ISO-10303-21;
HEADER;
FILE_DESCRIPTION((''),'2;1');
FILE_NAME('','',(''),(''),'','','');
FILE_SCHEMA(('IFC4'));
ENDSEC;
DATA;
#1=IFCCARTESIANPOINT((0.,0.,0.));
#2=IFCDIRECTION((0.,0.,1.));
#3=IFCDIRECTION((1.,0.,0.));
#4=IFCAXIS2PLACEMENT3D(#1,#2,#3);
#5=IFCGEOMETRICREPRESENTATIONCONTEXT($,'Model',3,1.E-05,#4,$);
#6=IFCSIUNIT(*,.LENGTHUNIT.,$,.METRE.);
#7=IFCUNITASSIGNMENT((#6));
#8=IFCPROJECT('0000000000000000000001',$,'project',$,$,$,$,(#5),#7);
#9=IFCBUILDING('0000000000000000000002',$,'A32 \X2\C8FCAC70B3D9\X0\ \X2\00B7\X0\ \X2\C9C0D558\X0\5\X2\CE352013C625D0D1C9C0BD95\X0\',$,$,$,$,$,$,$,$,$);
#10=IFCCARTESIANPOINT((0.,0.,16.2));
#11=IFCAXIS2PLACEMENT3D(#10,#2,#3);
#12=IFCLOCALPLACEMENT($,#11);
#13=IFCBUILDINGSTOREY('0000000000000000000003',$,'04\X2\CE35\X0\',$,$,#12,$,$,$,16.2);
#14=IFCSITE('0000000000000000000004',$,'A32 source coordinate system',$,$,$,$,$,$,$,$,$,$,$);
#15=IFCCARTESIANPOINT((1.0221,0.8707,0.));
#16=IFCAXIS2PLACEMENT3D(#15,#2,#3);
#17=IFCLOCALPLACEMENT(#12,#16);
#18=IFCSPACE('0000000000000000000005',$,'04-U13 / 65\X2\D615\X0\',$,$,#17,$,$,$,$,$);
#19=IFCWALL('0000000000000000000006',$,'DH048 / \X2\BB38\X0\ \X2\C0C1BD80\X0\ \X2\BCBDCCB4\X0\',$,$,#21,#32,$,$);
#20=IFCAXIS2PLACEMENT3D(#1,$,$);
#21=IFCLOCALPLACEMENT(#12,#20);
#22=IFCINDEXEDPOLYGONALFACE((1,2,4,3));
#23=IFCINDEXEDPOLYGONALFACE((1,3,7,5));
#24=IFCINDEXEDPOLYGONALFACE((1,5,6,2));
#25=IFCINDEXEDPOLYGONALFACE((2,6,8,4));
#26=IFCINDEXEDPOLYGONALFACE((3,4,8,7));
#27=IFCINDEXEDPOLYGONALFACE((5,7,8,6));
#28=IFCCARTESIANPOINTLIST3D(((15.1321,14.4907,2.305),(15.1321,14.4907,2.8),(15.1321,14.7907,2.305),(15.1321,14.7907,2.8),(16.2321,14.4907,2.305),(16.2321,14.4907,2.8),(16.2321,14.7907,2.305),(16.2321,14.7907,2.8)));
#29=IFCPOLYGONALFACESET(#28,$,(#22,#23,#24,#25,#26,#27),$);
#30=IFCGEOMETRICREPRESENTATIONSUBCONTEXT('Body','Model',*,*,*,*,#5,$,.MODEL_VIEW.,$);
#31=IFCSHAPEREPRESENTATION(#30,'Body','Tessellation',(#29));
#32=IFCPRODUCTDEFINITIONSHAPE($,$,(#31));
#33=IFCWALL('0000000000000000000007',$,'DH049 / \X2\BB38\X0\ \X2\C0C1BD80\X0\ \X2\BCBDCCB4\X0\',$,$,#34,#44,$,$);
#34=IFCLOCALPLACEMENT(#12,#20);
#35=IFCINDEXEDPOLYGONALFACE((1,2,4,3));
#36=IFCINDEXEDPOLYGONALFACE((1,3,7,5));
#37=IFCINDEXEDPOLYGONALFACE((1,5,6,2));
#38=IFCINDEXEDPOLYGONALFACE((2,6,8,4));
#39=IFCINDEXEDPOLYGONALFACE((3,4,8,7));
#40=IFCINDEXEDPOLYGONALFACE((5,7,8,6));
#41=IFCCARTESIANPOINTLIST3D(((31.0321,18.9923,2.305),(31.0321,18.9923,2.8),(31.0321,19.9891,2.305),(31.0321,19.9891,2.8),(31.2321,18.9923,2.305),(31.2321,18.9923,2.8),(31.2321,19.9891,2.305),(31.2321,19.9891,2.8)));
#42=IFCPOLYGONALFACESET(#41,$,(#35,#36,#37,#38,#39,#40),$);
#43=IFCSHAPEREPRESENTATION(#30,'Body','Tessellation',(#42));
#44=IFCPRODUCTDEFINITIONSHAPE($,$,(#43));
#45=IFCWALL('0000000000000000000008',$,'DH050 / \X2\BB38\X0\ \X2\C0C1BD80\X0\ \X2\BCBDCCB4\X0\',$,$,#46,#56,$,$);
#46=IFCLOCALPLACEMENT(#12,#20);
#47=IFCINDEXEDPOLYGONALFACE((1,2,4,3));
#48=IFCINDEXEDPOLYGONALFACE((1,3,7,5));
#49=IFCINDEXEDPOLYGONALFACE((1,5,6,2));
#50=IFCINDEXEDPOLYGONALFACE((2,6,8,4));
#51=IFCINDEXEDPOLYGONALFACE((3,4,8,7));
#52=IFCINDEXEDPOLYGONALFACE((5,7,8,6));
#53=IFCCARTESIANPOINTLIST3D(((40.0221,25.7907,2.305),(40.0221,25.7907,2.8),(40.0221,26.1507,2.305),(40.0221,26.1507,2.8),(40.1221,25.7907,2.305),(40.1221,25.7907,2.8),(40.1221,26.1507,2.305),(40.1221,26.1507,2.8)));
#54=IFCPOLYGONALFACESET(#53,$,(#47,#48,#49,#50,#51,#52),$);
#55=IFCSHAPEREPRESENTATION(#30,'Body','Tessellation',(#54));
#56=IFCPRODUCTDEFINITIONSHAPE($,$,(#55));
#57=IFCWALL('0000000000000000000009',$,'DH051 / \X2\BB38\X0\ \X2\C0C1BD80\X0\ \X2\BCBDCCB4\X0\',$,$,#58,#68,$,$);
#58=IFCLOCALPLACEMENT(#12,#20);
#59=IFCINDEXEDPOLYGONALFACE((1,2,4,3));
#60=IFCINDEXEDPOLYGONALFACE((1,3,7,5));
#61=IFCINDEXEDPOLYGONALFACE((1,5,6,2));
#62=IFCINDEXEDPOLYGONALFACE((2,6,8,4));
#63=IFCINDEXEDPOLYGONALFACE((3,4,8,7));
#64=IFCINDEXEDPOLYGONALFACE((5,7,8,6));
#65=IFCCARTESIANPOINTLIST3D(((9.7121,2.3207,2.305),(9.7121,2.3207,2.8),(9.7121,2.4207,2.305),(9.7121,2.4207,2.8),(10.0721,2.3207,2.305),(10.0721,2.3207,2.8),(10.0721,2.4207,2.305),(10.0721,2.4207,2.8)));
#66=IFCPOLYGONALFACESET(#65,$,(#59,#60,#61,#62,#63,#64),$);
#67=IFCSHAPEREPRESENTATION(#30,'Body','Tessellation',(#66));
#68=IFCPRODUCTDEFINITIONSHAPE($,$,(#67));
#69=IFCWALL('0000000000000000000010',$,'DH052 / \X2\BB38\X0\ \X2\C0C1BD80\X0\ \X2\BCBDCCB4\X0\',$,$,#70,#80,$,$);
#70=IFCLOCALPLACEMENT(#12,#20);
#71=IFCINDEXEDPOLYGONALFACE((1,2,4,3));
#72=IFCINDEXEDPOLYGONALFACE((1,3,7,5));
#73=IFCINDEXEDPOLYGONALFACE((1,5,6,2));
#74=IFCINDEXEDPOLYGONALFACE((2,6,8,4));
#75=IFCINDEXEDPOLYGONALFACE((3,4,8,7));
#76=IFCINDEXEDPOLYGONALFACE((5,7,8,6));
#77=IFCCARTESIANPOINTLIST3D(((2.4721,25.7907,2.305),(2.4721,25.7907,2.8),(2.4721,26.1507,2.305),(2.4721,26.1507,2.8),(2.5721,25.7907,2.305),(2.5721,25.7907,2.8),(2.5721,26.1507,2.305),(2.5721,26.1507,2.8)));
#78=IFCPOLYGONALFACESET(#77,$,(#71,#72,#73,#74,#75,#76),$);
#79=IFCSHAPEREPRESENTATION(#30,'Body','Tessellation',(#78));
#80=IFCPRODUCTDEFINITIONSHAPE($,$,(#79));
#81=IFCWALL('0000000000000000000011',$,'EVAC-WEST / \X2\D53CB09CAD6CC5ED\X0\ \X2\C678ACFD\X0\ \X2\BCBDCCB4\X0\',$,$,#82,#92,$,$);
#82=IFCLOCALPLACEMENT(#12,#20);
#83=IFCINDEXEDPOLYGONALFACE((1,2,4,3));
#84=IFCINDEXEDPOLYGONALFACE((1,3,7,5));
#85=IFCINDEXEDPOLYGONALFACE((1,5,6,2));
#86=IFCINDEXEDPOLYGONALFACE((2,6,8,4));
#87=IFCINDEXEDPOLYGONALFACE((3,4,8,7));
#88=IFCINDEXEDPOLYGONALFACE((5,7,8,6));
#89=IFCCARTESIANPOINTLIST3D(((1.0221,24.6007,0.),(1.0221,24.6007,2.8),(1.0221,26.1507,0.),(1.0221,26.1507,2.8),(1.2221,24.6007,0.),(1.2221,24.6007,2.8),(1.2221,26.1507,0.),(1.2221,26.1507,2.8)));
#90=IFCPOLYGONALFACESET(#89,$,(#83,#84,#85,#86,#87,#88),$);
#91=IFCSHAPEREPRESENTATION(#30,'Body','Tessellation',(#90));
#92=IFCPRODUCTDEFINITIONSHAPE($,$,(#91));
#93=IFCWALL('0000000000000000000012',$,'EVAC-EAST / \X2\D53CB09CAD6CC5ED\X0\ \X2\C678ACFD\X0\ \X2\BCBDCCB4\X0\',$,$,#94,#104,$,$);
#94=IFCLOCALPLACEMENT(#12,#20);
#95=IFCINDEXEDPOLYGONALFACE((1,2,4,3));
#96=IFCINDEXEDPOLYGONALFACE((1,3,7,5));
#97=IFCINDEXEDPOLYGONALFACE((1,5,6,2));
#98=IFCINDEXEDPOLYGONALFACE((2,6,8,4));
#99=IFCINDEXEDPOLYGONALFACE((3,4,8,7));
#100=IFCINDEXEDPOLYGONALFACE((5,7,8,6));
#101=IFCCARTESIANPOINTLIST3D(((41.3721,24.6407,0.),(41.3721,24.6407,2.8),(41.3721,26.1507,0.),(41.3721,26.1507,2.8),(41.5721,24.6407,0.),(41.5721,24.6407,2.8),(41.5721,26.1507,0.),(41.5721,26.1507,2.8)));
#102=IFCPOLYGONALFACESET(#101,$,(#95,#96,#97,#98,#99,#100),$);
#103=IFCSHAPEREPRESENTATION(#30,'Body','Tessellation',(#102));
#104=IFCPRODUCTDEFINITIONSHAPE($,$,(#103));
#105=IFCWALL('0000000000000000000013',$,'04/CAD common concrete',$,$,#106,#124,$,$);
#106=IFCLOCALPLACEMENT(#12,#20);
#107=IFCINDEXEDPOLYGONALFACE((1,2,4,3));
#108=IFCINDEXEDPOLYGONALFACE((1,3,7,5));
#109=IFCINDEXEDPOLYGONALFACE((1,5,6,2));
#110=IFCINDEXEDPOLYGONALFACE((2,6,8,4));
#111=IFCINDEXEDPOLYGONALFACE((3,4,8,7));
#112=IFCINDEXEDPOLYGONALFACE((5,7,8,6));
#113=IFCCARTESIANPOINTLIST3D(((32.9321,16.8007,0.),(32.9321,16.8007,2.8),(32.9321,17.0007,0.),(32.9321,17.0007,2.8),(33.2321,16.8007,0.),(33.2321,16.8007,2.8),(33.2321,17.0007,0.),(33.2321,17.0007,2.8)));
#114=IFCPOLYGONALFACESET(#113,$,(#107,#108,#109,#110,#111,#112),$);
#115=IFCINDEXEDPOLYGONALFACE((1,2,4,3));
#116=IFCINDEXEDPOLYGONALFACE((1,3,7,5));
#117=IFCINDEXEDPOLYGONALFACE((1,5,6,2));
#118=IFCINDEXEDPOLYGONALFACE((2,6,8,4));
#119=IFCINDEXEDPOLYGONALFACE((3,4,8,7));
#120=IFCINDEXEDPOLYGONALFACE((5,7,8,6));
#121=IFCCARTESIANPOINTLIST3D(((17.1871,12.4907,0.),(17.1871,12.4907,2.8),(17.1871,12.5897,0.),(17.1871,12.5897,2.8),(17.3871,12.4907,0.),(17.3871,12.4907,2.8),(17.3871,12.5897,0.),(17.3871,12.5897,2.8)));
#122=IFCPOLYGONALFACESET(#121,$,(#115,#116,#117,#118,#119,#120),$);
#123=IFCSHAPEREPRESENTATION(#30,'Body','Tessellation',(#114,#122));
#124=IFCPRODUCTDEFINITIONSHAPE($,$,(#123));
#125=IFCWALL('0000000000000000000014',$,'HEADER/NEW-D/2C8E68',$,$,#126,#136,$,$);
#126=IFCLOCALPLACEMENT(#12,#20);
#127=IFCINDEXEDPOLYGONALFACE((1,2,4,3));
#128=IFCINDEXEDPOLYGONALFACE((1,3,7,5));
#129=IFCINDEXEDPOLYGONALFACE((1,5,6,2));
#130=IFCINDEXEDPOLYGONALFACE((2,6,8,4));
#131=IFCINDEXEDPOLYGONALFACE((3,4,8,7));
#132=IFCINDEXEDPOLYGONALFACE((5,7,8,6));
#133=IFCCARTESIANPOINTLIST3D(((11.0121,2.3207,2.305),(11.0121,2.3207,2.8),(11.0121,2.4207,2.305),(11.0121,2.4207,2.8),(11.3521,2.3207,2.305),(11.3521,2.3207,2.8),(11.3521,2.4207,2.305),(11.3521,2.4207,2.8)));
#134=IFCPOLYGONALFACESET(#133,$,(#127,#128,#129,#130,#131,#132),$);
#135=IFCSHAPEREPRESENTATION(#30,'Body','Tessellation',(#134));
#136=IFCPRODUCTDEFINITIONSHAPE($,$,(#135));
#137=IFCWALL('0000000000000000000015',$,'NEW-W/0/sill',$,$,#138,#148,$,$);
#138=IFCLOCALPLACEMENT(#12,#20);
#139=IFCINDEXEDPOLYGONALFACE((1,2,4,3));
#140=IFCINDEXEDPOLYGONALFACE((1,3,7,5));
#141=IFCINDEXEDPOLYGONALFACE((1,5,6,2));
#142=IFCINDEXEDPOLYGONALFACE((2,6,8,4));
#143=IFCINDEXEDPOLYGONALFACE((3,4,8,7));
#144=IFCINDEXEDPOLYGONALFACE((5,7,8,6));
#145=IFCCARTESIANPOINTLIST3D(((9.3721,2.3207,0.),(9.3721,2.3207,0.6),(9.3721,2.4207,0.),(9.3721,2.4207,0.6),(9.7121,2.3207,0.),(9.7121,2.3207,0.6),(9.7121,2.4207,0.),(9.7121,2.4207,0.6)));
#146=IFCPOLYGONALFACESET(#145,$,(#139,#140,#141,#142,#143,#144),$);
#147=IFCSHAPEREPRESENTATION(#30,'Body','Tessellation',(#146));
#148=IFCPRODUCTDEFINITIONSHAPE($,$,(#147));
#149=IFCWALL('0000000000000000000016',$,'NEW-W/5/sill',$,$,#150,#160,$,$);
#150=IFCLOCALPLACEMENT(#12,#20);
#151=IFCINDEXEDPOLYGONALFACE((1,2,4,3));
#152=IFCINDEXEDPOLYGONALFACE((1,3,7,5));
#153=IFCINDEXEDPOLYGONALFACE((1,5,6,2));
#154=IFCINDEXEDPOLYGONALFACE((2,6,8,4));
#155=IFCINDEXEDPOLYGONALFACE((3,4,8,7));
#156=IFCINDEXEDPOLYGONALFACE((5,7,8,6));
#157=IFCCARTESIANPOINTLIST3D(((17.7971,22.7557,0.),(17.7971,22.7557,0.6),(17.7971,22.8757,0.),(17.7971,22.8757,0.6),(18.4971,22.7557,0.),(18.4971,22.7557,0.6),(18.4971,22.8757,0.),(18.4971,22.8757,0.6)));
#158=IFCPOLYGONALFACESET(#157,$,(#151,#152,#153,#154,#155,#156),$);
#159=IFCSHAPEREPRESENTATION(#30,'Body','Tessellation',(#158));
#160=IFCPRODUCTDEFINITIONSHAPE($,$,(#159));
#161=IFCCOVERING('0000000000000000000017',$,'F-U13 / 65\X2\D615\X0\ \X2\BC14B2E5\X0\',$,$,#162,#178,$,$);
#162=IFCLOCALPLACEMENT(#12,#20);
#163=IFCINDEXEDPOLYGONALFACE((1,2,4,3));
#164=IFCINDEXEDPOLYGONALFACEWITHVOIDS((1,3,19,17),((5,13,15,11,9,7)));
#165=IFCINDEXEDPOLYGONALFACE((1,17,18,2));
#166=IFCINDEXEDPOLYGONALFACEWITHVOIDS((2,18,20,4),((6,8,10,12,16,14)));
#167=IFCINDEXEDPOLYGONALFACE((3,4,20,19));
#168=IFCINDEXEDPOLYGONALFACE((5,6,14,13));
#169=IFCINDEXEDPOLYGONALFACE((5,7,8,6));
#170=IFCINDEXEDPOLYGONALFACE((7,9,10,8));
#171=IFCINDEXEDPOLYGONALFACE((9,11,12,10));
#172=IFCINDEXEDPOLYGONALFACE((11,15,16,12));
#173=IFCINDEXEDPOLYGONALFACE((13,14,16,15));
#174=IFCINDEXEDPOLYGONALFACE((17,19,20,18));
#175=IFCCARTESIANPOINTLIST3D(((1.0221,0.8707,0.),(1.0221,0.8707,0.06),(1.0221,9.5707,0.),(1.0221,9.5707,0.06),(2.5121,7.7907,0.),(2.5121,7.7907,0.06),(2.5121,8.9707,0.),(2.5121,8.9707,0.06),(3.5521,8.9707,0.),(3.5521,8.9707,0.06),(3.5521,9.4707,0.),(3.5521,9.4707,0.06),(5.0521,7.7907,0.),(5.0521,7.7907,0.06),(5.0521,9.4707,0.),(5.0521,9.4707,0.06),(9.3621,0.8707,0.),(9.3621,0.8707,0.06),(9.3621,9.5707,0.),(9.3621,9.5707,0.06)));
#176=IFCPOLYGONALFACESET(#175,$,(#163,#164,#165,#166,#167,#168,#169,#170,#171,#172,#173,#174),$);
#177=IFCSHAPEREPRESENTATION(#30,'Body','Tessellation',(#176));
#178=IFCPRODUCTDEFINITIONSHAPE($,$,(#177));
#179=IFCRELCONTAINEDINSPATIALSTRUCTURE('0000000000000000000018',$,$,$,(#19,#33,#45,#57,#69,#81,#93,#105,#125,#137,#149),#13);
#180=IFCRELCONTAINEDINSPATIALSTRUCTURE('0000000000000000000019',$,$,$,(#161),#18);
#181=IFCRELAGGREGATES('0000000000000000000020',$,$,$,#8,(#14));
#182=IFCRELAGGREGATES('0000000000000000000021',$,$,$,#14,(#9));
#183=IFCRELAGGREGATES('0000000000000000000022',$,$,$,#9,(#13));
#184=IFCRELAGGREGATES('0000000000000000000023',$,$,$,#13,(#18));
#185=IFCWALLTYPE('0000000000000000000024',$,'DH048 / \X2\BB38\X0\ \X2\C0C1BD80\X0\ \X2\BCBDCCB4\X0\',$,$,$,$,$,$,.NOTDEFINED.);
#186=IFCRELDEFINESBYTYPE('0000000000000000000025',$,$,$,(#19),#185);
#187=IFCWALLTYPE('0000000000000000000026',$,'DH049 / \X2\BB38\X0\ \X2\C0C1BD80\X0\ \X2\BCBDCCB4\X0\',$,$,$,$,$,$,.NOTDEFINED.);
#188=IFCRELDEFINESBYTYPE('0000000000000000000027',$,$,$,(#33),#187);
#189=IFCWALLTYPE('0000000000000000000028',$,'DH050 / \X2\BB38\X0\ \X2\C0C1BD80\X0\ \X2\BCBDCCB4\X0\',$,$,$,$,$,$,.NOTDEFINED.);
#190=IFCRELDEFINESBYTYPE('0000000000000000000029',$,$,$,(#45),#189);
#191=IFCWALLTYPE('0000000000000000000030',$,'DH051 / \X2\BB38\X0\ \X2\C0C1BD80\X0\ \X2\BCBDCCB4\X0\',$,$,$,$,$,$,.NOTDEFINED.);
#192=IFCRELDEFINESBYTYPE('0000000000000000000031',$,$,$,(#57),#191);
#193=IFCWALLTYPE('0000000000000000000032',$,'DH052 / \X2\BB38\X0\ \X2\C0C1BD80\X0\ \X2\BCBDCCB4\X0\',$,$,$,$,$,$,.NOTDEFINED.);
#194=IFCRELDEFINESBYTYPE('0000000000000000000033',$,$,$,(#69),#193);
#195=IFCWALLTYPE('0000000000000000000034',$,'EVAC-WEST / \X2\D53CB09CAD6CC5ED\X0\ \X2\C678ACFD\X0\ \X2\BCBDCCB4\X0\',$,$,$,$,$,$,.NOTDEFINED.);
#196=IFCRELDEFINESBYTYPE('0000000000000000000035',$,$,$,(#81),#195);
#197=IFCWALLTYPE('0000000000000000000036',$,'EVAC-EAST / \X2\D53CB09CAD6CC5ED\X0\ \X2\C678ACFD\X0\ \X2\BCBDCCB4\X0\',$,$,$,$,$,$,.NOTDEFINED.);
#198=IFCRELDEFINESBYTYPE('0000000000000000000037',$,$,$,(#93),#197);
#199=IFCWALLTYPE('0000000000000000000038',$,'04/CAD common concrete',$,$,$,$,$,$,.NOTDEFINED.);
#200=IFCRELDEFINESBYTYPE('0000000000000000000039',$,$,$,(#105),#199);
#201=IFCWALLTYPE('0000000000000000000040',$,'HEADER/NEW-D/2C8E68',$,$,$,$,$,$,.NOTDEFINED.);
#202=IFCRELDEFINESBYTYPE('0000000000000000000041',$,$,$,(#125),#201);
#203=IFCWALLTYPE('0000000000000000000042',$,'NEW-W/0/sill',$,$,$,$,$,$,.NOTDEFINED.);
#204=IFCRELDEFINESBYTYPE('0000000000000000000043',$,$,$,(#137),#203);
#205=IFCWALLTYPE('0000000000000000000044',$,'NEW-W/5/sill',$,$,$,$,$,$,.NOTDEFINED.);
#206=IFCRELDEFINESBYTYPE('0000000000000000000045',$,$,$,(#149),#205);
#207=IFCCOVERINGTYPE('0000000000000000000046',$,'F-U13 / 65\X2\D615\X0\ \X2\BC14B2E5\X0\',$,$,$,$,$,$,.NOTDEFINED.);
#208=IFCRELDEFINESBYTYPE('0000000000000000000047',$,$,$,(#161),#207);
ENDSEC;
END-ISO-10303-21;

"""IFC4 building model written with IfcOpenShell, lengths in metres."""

from ifc_helpers import new_model, si_unit, frame, origin, origin_with_axes, place, context, subcontext, project, spatial, polyline, outline, extrude, source, transform, mapped, type_object, type_shapes, element, save


model = new_model("IFC4")

# Units and contexts
model_context = context("Model", 3, precision=1e-05, world=origin_with_axes())
body_context = subcontext(model_context, "Body", "Model", "MODEL_VIEW")
ifc_project = project(units=[si_unit("LENGTHUNIT", "METRE")], contexts=[model_context])

# Site, building, storey
site = spatial("IfcSite", under=ifc_project, Name="A32 source coordinate system")
building = spatial("IfcBuilding", under=site, Name="A32 주거동 · 지하5층–옥탑지붕")
storey_placement = place(None, frame((0.0, 0.0, 16.2), z_axis=(0.0, 0.0, 1.0), x_axis=(1.0, 0.0, 0.0)))
storey = spatial("IfcBuildingStorey", under=building, at=storey_placement, Name="04층", Elevation=16.2)

# Walls
wall_type_1 = type_object("IfcWallType", Name="DH048 / 문 상부 벽체", PredefinedType="NOTDEFINED")
shared_shape_1 = source(origin(), body_context, "Body", "SweptSolid", [
    extrude(outline(polyline([(15.1321, 14.7907), (16.2321, 14.7907), (16.2321, 14.4907), (15.1321, 14.4907), (15.1321, 14.7907)])), frame((0.0, 0.0, 2.305)), (0.0, 0.0, 1.0), 0.495),
])
type_shapes(wall_type_1, [shared_shape_1])
wall_1_placement = place(storey_placement, origin_with_axes())
element("IfcWall", 1, at=wall_1_placement, inside=storey, type_object=wall_type_1, Name="DH048 / 문 상부 벽체", context=body_context, shape_type="MappedRepresentation", body=[
    mapped(shared_shape_1, transform((0.0, 0.0, 0.0), scale=1.0)),
])
wall_type_2 = type_object("IfcWallType", Name="DH049 / 문 상부 벽체", PredefinedType="NOTDEFINED")
shared_shape_2 = source(origin(), body_context, "Body", "SweptSolid", [
    extrude(outline(polyline([(31.2321, 18.9923), (31.0321, 18.9923), (31.0321, 19.9891), (31.2321, 19.9891), (31.2321, 18.9923)])), frame((0.0, 0.0, 2.305)), (0.0, 0.0, 1.0), 0.495),
])
type_shapes(wall_type_2, [shared_shape_2])
wall_2_placement = place(storey_placement, origin_with_axes())
element("IfcWall", 2, at=wall_2_placement, inside=storey, type_object=wall_type_2, Name="DH049 / 문 상부 벽체", context=body_context, shape_type="MappedRepresentation", body=[
    mapped(shared_shape_2, transform((0.0, 0.0, 0.0), scale=1.0)),
])
wall_type_3 = type_object("IfcWallType", Name="DH050 / 문 상부 벽체", PredefinedType="NOTDEFINED")
shared_shape_3 = source(origin(), body_context, "Body", "SweptSolid", [
    extrude(outline(polyline([(40.0221, 25.7907), (40.0221, 26.1507), (40.1221, 26.1507), (40.1221, 25.7907), (40.0221, 25.7907)])), frame((0.0, 0.0, 2.305)), (0.0, 0.0, 1.0), 0.495),
])
type_shapes(wall_type_3, [shared_shape_3])
wall_3_placement = place(storey_placement, origin_with_axes())
element("IfcWall", 3, at=wall_3_placement, inside=storey, type_object=wall_type_3, Name="DH050 / 문 상부 벽체", context=body_context, shape_type="MappedRepresentation", body=[
    mapped(shared_shape_3, transform((0.0, 0.0, 0.0), scale=1.0)),
])
wall_type_4 = type_object("IfcWallType", Name="DH051 / 문 상부 벽체", PredefinedType="NOTDEFINED")
shared_shape_4 = source(origin(), body_context, "Body", "SweptSolid", [
    extrude(outline(polyline([(10.0721, 2.3207), (9.7121, 2.3207), (9.7121, 2.4207), (10.0721, 2.4207), (10.0721, 2.3207)])), frame((0.0, 0.0, 2.305)), (0.0, 0.0, 1.0), 0.495),
])
type_shapes(wall_type_4, [shared_shape_4])
wall_4_placement = place(storey_placement, origin_with_axes())
element("IfcWall", 4, at=wall_4_placement, inside=storey, type_object=wall_type_4, Name="DH051 / 문 상부 벽체", context=body_context, shape_type="MappedRepresentation", body=[
    mapped(shared_shape_4, transform((0.0, 0.0, 0.0), scale=1.0)),
])
wall_type_5 = type_object("IfcWallType", Name="DH052 / 문 상부 벽체", PredefinedType="NOTDEFINED")
shared_shape_5 = source(origin(), body_context, "Body", "SweptSolid", [
    extrude(outline(polyline([(2.5721, 25.7907), (2.4721, 25.7907), (2.4721, 26.1507), (2.5721, 26.1507), (2.5721, 25.7907)])), frame((0.0, 0.0, 2.305)), (0.0, 0.0, 1.0), 0.495),
])
type_shapes(wall_type_5, [shared_shape_5])
wall_5_placement = place(storey_placement, origin_with_axes())
element("IfcWall", 5, at=wall_5_placement, inside=storey, type_object=wall_type_5, Name="DH052 / 문 상부 벽체", context=body_context, shape_type="MappedRepresentation", body=[
    mapped(shared_shape_5, transform((0.0, 0.0, 0.0), scale=1.0)),
])
wall_type_6 = type_object("IfcWallType", Name="EVAC-WEST / 피난구역 외곽 벽체", PredefinedType="NOTDEFINED")
shared_shape_6 = source(origin(), body_context, "Body", "SweptSolid", [
    extrude(outline(polyline([(1.2221, 24.6007), (1.0221, 24.6007), (1.0221, 26.1507), (1.2221, 26.1507), (1.2221, 24.6007)])), origin(), (0.0, 0.0, 1.0), 2.8),
])
type_shapes(wall_type_6, [shared_shape_6])
wall_6_placement = place(storey_placement, origin_with_axes())
element("IfcWall", 6, at=wall_6_placement, inside=storey, type_object=wall_type_6, Name="EVAC-WEST / 피난구역 외곽 벽체", context=body_context, shape_type="MappedRepresentation", body=[
    mapped(shared_shape_6, transform((0.0, 0.0, 0.0), scale=1.0)),
])
wall_type_7 = type_object("IfcWallType", Name="EVAC-EAST / 피난구역 외곽 벽체", PredefinedType="NOTDEFINED")
shared_shape_7 = source(origin(), body_context, "Body", "SweptSolid", [
    extrude(outline(polyline([(41.5721, 26.1507), (41.5721, 24.6407), (41.3721, 24.6407), (41.3721, 26.1507), (41.5721, 26.1507)])), origin(), (0.0, 0.0, 1.0), 2.8),
])
type_shapes(wall_type_7, [shared_shape_7])
wall_7_placement = place(storey_placement, origin_with_axes())
element("IfcWall", 7, at=wall_7_placement, inside=storey, type_object=wall_type_7, Name="EVAC-EAST / 피난구역 외곽 벽체", context=body_context, shape_type="MappedRepresentation", body=[
    mapped(shared_shape_7, transform((0.0, 0.0, 0.0), scale=1.0)),
])
wall_type_8 = type_object("IfcWallType", Name="04/CAD common concrete", PredefinedType="NOTDEFINED")
shared_shape_8 = source(origin(), body_context, "Body", "SweptSolid", [
    extrude(outline(polyline([(32.9321, 17.0007), (33.2321, 17.0007), (33.2321, 16.8007), (32.9321, 16.8007), (32.9321, 17.0007)])), origin(), (0.0, 0.0, 1.0), 2.8),
    extrude(outline(polyline([(17.1871, 12.4907), (17.1871, 12.5897), (17.3871, 12.5897), (17.3871, 12.4907), (17.1871, 12.4907)])), origin(), (0.0, 0.0, 1.0), 2.8),
])
type_shapes(wall_type_8, [shared_shape_8])
wall_8_placement = place(storey_placement, origin_with_axes())
element("IfcWall", 8, at=wall_8_placement, inside=storey, type_object=wall_type_8, Name="04/CAD common concrete", context=body_context, shape_type="MappedRepresentation", body=[
    mapped(shared_shape_8, transform((0.0, 0.0, 0.0), scale=1.0)),
])
wall_type_9 = type_object("IfcWallType", Name="HEADER/NEW-D/2C8E68", PredefinedType="NOTDEFINED")
shared_shape_9 = source(origin(), body_context, "Body", "SweptSolid", [
    extrude(outline(polyline([(10.6521, 2.4207), (11.3521, 2.4207), (11.3521, 2.3207), (11.0121, 2.3207), (11.0121, 2.4207), (10.6521, 2.4207), (10.6521, 2.4207)])), frame((0.0, 0.0, 2.305)), (0.0, 0.0, 1.0), 0.495),
])
type_shapes(wall_type_9, [shared_shape_9])
wall_9_placement = place(storey_placement, origin_with_axes())
element("IfcWall", 9, at=wall_9_placement, inside=storey, type_object=wall_type_9, Name="HEADER/NEW-D/2C8E68", context=body_context, shape_type="MappedRepresentation", body=[
    mapped(shared_shape_9, transform((0.0, 0.0, 0.0), scale=1.0)),
])
wall_type_10 = type_object("IfcWallType", Name="NEW-W/0/sill", PredefinedType="NOTDEFINED")
shared_shape_10 = source(origin(), body_context, "Body", "SweptSolid", [
    extrude(outline(polyline([(9.3721, 2.3207), (9.3721, 2.4207), (10.6521, 2.4207), (10.6521, 2.4207), (10.0721, 2.4207), (9.7121, 2.4207), (9.7121, 2.3207), (9.3721, 2.3207)])), origin(), (0.0, 0.0, 1.0), 0.6),
])
type_shapes(wall_type_10, [shared_shape_10])
wall_10_placement = place(storey_placement, origin_with_axes())
element("IfcWall", 10, at=wall_10_placement, inside=storey, type_object=wall_type_10, Name="NEW-W/0/sill", context=body_context, shape_type="MappedRepresentation", body=[
    mapped(shared_shape_10, transform((0.0, 0.0, 0.0), scale=1.0)),
])
wall_type_11 = type_object("IfcWallType", Name="NEW-W/5/sill", PredefinedType="NOTDEFINED")
shared_shape_11 = source(origin(), body_context, "Body", "SweptSolid", [
    extrude(outline(polyline([(17.7971, 22.7557), (17.7971, 22.8757), (18.4971, 22.8757), (18.4971, 22.7557), (17.7971, 22.7557)])), origin(), (0.0, 0.0, 1.0), 0.6),
])
type_shapes(wall_type_11, [shared_shape_11])
wall_11_placement = place(storey_placement, origin_with_axes())
element("IfcWall", 11, at=wall_11_placement, inside=storey, type_object=wall_type_11, Name="NEW-W/5/sill", context=body_context, shape_type="MappedRepresentation", body=[
    mapped(shared_shape_11, transform((0.0, 0.0, 0.0), scale=1.0)),
])

# Shared definitions
space_placement = place(storey_placement, frame((1.0221, 0.8707, 0.0), z_axis=(0.0, 0.0, 1.0), x_axis=(1.0, 0.0, 0.0)))
space = spatial("IfcSpace", under=storey, at=space_placement, Name="04-U13 / 65형")

# Covering
covering_type_1 = type_object("IfcCoveringType", Name="F-U13 / 65형 바닥", PredefinedType="NOTDEFINED")
shared_shape_12 = source(origin(), body_context, "Body", "SweptSolid", [
    extrude(outline(polyline([(0.0, 0.0), (0.0, 8.7), (8.34, 8.7), (8.34, 0.0), (0.0, 0.0)]), holes=[polyline([(2.53, 8.1), (1.49, 8.1), (1.49, 6.92), (4.03, 6.92), (4.03, 8.6), (2.53, 8.6), (2.53, 8.1)])]), origin(), (0.0, 0.0, 1.0), 0.06),
])
type_shapes(covering_type_1, [shared_shape_12])
covering_1_placement = place(space_placement, origin_with_axes())
element("IfcCovering", 12, at=covering_1_placement, inside=space, type_object=covering_type_1, Name="F-U13 / 65형 바닥", context=body_context, shape_type="MappedRepresentation", body=[
    mapped(shared_shape_12, transform((0.0, 0.0, 0.0), scale=1.0)),
])

save(model, "model.ifc")
